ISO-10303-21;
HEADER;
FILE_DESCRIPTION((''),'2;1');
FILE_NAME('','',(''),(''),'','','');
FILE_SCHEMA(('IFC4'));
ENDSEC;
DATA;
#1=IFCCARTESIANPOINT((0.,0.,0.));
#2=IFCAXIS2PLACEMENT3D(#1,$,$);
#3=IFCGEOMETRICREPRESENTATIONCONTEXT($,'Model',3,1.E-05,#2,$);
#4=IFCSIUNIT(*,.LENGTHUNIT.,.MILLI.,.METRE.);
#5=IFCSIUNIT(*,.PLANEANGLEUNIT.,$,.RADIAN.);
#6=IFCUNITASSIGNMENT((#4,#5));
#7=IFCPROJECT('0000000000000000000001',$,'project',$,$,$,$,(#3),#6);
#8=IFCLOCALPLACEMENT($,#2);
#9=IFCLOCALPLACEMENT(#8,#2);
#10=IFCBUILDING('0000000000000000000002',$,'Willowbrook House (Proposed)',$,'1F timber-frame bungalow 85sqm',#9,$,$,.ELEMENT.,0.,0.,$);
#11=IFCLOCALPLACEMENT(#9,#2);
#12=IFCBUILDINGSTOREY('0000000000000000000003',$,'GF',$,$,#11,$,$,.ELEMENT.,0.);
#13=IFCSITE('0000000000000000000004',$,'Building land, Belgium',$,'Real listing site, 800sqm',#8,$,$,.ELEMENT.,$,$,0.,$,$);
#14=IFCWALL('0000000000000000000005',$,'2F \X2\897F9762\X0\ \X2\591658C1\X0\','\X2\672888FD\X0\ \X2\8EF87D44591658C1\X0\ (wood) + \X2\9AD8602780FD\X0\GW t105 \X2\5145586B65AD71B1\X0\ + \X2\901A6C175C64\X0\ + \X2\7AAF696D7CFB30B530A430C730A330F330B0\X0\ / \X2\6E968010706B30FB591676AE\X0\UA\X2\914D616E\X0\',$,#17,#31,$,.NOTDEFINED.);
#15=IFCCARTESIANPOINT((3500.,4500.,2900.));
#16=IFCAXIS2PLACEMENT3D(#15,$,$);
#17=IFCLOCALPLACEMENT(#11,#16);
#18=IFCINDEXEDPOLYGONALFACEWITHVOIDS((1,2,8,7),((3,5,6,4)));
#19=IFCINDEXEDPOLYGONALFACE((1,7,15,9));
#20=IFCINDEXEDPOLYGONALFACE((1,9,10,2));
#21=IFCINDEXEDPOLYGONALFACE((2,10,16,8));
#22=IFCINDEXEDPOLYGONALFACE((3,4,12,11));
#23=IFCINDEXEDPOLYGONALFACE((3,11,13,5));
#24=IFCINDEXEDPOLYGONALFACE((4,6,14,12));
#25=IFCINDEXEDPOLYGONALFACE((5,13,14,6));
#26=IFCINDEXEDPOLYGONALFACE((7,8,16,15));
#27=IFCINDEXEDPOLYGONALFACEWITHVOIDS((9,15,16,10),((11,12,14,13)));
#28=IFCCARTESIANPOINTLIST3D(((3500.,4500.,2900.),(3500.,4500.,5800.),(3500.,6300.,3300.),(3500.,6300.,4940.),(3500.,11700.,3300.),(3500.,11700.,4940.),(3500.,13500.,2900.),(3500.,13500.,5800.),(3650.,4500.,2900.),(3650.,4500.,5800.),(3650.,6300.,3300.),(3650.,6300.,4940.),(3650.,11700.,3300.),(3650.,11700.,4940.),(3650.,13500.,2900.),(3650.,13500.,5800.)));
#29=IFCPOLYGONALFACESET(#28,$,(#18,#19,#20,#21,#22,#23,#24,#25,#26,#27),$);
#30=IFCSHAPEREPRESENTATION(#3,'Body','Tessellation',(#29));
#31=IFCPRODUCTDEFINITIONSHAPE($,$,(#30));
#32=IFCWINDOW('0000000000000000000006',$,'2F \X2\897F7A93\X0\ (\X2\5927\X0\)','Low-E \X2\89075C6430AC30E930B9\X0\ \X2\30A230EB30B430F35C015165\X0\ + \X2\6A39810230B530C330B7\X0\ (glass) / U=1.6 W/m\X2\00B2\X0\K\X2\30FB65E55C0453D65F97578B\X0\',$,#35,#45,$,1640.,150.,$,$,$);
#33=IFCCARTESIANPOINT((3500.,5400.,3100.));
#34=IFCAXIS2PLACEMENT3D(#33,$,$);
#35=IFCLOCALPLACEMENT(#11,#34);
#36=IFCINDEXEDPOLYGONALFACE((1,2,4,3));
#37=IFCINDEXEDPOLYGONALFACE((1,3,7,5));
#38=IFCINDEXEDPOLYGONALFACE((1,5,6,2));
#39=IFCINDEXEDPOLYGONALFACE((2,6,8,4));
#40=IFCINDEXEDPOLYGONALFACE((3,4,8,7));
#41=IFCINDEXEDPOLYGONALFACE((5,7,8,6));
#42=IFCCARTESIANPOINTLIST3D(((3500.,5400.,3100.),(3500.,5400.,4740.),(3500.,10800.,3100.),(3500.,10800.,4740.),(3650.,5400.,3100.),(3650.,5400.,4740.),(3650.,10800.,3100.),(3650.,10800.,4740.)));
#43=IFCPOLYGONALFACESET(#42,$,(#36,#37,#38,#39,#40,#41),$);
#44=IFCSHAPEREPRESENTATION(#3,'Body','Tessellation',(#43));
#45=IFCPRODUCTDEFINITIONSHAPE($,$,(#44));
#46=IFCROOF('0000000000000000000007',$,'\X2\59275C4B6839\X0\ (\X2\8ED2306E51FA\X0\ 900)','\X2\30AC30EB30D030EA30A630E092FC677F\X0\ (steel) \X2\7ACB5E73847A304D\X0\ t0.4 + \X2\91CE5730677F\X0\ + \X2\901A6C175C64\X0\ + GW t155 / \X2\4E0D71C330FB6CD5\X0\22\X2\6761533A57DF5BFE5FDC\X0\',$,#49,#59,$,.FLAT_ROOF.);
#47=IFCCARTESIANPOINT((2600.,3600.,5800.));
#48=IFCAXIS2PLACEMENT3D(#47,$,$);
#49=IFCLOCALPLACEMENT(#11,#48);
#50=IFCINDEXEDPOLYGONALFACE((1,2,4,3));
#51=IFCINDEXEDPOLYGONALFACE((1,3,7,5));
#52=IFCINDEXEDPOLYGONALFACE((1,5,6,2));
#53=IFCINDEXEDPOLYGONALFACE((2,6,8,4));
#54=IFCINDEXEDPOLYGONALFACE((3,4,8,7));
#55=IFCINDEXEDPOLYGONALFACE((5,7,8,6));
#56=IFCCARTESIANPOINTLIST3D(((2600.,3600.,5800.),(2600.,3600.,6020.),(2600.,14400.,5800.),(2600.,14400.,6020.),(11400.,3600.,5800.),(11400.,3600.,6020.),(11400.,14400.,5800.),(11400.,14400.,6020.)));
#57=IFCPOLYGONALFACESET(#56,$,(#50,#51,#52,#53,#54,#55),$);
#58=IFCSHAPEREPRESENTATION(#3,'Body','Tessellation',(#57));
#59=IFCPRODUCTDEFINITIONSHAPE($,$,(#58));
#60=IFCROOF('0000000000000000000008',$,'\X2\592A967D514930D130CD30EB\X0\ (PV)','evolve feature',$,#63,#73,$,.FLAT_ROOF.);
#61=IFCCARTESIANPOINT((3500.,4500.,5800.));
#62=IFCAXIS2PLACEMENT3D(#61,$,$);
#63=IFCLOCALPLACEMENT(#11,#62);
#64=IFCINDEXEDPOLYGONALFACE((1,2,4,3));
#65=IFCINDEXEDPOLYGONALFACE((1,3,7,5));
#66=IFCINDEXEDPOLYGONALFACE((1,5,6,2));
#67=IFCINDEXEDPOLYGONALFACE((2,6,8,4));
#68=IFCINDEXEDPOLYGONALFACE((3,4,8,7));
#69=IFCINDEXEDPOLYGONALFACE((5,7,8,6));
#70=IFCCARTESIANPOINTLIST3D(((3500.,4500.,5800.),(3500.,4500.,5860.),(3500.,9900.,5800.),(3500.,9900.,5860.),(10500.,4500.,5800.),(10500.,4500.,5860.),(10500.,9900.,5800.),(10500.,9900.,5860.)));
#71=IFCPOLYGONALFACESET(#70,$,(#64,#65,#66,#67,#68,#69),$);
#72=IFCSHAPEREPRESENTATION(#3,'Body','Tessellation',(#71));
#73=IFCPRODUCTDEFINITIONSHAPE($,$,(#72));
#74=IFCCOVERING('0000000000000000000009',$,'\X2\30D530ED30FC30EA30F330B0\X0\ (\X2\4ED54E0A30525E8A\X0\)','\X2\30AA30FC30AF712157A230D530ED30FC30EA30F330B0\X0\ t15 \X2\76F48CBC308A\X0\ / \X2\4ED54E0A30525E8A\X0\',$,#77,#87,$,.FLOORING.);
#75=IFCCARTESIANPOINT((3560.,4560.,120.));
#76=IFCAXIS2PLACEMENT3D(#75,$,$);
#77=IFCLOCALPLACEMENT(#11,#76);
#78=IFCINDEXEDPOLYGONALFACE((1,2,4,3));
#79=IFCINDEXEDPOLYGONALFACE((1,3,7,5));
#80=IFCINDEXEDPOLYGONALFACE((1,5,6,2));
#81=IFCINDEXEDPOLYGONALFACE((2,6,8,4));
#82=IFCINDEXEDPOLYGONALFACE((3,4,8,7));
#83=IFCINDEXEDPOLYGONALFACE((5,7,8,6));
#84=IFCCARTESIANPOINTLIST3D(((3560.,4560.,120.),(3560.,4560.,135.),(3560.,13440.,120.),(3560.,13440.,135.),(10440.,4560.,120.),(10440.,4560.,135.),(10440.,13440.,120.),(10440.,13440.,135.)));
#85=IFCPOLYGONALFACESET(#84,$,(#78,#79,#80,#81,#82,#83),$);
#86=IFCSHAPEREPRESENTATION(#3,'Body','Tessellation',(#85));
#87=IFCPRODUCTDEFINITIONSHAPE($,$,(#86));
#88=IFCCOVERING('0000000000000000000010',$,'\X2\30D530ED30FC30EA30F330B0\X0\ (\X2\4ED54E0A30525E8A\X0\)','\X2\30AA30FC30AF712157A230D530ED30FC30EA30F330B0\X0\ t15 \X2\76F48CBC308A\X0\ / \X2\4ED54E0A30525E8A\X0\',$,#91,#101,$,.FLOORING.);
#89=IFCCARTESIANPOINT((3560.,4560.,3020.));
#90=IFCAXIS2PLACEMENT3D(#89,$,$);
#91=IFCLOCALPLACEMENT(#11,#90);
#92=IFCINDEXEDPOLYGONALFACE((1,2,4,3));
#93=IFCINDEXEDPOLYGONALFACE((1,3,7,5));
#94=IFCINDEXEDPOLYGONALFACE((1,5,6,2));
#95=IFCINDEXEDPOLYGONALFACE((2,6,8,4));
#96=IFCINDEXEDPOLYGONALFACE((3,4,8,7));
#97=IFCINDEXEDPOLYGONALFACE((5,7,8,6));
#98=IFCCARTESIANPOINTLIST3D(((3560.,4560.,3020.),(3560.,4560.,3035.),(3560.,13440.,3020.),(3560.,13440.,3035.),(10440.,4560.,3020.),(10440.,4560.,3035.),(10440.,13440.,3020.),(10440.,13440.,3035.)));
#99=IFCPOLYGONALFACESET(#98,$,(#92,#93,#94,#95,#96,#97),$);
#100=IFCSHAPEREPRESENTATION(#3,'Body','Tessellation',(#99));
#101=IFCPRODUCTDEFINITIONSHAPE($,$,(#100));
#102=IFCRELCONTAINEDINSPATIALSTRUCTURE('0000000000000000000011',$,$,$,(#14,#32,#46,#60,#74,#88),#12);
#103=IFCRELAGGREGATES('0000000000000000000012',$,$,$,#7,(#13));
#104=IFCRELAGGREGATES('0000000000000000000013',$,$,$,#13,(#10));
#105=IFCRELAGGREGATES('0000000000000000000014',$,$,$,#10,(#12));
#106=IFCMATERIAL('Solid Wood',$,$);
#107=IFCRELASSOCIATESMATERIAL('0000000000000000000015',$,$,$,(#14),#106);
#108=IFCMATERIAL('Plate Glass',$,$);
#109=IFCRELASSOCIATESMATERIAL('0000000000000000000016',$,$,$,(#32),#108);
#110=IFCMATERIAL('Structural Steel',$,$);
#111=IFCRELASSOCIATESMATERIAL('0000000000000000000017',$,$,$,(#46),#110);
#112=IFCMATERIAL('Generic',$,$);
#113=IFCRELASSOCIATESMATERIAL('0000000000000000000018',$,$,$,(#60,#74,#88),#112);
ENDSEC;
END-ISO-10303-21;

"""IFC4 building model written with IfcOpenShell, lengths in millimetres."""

from ifc_helpers import new_model, si_unit, frame, frame_2d, origin, place, context, project, spatial, rectangle, extrude, material, element, fill, save


model = new_model("IFC4")

# Units and contexts
model_context = context("Model", 3, precision=1e-05, world=origin())
ifc_project = project(units=[si_unit("LENGTHUNIT", "METRE", prefix="MILLI"), si_unit("PLANEANGLEUNIT", "RADIAN")], contexts=[model_context])

# Site, building, storey
site_placement = place(None, origin())
site = spatial("IfcSite", under=ifc_project, at=site_placement, Name="Building land, Belgium", ObjectType="Real listing site, 800sqm", CompositionType="ELEMENT", RefElevation=0.0)
building_placement = place(site_placement, origin())
building = spatial("IfcBuilding", under=site, at=building_placement, Name="Willowbrook House (Proposed)", ObjectType="1F timber-frame bungalow 85sqm", CompositionType="ELEMENT", ElevationOfRefHeight=0.0, ElevationOfTerrain=0.0)
storey_placement = place(building_placement, origin())
storey = spatial("IfcBuildingStorey", under=building, at=storey_placement, Name="GF", CompositionType="ELEMENT", Elevation=0.0)

# Shared definitions
ifc_material_1 = material(Name="Solid Wood")
ifc_material_2 = material(Name="Generic")

# Shared definitions
ifc_material_3 = material(Name="Plate Glass")

# Wall, opening, window
wall_1_placement = place(storey_placement, frame((3500.0, 4500.0, 2900.0)))
wall_1 = element("IfcWall", 1, at=wall_1_placement, inside=storey, material=ifc_material_1, Name="2F 西面 外壁", Description="木製 軸組外壁 (wood) + 高性能GW t105 充填断熱 + 通気層 + 窯業系サイディング / 準耐火・外皮UA配慮", PredefinedType="NOTDEFINED", context=model_context, shape_type="SweptSolid", body=[
    extrude(rectangle(XDim=150.0, YDim=9000.0, at=frame_2d((75.0, 4500.0))), frame((3500.0, 4500.0, 2900.0)), (0.0, 0.0, 1.0), 2900.0),
])
opening_1_placement = place(storey_placement, frame((3500.0, 5400.0, 3100.0)))
opening_1 = element("IfcOpeningElement", 2, at=opening_1_placement, cuts=wall_1, PredefinedType="NOTDEFINED", context=model_context, shape_type="SweptSolid", body=[
    extrude(rectangle(XDim=150.0, YDim=5400.0, at=frame_2d((75.0, 2700.0))), frame((3500.0, 5400.0, 3100.0)), (0.0, 0.0, 1.0), 1640.0),
])
window_1_placement = place(storey_placement, frame((3500.0, 5400.0, 3100.0)))
window_1 = element("IfcWindow", 3, at=window_1_placement, inside=storey, material=ifc_material_3, Name="2F 西窓 (大)", Description="Low-E 複層ガラス アルゴン封入 + 樹脂サッシ (glass) / U=1.6 W/m²K・日射取得型", OverallHeight=1640.0, OverallWidth=150.0, context=model_context, shape_type="SweptSolid", body=[
    extrude(rectangle(XDim=150.0, YDim=5400.0, at=frame_2d((75.0, 2700.0))), frame((3500.0, 5400.0, 3100.0)), (0.0, 0.0, 1.0), 1640.0),
])
fill(opening_1, window_1)

# Roofs
ifc_material_4 = material(Name="Structural Steel")
roof_1_placement = place(storey_placement, frame((2600.0, 3600.0, 5800.0)))
element("IfcRoof", 4, at=roof_1_placement, inside=storey, material=ifc_material_4, Name="大屋根 (軒の出 900)", Description="ガルバリウム鋼板 (steel) 立平葺き t0.4 + 野地板 + 通気層 + GW t155 / 不燃・法22条区域対応", PredefinedType="FLAT_ROOF", context=model_context, shape_type="SweptSolid", body=[
    extrude(rectangle(XDim=8800.0, YDim=10800.0, at=frame_2d((4400.0, 5400.0))), frame((2600.0, 3600.0, 5800.0)), (0.0, 0.0, 1.0), 220.0),
])
roof_2_placement = place(storey_placement, frame((3500.0, 4500.0, 5800.0)))
element("IfcRoof", 5, at=roof_2_placement, inside=storey, material=ifc_material_2, Name="太陽光パネル (PV)", Description="evolve feature", PredefinedType="FLAT_ROOF", context=model_context, shape_type="SweptSolid", body=[
    extrude(rectangle(XDim=7000.0, YDim=5400.0, at=frame_2d((3500.0, 2700.0))), frame((3500.0, 4500.0, 5800.0)), (0.0, 0.0, 1.0), 60.0),
])

# Coverings
covering_1_placement = place(storey_placement, frame((3560.0, 4560.0, 120.0)))
element("IfcCovering", 6, at=covering_1_placement, inside=storey, material=ifc_material_2, Name="フローリング (仕上げ床)", Description="オーク無垢フローリング t15 直貼り / 仕上げ床", PredefinedType="FLOORING", context=model_context, shape_type="SweptSolid", body=[
    extrude(rectangle(XDim=6880.0, YDim=8880.0, at=frame_2d((3440.0, 4440.0))), frame((3560.0, 4560.0, 120.0)), (0.0, 0.0, 1.0), 15.0),
])
covering_2_placement = place(storey_placement, frame((3560.0, 4560.0, 3020.0)))
element("IfcCovering", 7, at=covering_2_placement, inside=storey, material=ifc_material_2, Name="フローリング (仕上げ床)", Description="オーク無垢フローリング t15 直貼り / 仕上げ床", PredefinedType="FLOORING", context=model_context, shape_type="SweptSolid", body=[
    extrude(rectangle(XDim=6880.0, YDim=8880.0, at=frame_2d((3440.0, 4440.0))), frame((3560.0, 4560.0, 3020.0)), (0.0, 0.0, 1.0), 15.0),
])

save(model, "model.ifc")
